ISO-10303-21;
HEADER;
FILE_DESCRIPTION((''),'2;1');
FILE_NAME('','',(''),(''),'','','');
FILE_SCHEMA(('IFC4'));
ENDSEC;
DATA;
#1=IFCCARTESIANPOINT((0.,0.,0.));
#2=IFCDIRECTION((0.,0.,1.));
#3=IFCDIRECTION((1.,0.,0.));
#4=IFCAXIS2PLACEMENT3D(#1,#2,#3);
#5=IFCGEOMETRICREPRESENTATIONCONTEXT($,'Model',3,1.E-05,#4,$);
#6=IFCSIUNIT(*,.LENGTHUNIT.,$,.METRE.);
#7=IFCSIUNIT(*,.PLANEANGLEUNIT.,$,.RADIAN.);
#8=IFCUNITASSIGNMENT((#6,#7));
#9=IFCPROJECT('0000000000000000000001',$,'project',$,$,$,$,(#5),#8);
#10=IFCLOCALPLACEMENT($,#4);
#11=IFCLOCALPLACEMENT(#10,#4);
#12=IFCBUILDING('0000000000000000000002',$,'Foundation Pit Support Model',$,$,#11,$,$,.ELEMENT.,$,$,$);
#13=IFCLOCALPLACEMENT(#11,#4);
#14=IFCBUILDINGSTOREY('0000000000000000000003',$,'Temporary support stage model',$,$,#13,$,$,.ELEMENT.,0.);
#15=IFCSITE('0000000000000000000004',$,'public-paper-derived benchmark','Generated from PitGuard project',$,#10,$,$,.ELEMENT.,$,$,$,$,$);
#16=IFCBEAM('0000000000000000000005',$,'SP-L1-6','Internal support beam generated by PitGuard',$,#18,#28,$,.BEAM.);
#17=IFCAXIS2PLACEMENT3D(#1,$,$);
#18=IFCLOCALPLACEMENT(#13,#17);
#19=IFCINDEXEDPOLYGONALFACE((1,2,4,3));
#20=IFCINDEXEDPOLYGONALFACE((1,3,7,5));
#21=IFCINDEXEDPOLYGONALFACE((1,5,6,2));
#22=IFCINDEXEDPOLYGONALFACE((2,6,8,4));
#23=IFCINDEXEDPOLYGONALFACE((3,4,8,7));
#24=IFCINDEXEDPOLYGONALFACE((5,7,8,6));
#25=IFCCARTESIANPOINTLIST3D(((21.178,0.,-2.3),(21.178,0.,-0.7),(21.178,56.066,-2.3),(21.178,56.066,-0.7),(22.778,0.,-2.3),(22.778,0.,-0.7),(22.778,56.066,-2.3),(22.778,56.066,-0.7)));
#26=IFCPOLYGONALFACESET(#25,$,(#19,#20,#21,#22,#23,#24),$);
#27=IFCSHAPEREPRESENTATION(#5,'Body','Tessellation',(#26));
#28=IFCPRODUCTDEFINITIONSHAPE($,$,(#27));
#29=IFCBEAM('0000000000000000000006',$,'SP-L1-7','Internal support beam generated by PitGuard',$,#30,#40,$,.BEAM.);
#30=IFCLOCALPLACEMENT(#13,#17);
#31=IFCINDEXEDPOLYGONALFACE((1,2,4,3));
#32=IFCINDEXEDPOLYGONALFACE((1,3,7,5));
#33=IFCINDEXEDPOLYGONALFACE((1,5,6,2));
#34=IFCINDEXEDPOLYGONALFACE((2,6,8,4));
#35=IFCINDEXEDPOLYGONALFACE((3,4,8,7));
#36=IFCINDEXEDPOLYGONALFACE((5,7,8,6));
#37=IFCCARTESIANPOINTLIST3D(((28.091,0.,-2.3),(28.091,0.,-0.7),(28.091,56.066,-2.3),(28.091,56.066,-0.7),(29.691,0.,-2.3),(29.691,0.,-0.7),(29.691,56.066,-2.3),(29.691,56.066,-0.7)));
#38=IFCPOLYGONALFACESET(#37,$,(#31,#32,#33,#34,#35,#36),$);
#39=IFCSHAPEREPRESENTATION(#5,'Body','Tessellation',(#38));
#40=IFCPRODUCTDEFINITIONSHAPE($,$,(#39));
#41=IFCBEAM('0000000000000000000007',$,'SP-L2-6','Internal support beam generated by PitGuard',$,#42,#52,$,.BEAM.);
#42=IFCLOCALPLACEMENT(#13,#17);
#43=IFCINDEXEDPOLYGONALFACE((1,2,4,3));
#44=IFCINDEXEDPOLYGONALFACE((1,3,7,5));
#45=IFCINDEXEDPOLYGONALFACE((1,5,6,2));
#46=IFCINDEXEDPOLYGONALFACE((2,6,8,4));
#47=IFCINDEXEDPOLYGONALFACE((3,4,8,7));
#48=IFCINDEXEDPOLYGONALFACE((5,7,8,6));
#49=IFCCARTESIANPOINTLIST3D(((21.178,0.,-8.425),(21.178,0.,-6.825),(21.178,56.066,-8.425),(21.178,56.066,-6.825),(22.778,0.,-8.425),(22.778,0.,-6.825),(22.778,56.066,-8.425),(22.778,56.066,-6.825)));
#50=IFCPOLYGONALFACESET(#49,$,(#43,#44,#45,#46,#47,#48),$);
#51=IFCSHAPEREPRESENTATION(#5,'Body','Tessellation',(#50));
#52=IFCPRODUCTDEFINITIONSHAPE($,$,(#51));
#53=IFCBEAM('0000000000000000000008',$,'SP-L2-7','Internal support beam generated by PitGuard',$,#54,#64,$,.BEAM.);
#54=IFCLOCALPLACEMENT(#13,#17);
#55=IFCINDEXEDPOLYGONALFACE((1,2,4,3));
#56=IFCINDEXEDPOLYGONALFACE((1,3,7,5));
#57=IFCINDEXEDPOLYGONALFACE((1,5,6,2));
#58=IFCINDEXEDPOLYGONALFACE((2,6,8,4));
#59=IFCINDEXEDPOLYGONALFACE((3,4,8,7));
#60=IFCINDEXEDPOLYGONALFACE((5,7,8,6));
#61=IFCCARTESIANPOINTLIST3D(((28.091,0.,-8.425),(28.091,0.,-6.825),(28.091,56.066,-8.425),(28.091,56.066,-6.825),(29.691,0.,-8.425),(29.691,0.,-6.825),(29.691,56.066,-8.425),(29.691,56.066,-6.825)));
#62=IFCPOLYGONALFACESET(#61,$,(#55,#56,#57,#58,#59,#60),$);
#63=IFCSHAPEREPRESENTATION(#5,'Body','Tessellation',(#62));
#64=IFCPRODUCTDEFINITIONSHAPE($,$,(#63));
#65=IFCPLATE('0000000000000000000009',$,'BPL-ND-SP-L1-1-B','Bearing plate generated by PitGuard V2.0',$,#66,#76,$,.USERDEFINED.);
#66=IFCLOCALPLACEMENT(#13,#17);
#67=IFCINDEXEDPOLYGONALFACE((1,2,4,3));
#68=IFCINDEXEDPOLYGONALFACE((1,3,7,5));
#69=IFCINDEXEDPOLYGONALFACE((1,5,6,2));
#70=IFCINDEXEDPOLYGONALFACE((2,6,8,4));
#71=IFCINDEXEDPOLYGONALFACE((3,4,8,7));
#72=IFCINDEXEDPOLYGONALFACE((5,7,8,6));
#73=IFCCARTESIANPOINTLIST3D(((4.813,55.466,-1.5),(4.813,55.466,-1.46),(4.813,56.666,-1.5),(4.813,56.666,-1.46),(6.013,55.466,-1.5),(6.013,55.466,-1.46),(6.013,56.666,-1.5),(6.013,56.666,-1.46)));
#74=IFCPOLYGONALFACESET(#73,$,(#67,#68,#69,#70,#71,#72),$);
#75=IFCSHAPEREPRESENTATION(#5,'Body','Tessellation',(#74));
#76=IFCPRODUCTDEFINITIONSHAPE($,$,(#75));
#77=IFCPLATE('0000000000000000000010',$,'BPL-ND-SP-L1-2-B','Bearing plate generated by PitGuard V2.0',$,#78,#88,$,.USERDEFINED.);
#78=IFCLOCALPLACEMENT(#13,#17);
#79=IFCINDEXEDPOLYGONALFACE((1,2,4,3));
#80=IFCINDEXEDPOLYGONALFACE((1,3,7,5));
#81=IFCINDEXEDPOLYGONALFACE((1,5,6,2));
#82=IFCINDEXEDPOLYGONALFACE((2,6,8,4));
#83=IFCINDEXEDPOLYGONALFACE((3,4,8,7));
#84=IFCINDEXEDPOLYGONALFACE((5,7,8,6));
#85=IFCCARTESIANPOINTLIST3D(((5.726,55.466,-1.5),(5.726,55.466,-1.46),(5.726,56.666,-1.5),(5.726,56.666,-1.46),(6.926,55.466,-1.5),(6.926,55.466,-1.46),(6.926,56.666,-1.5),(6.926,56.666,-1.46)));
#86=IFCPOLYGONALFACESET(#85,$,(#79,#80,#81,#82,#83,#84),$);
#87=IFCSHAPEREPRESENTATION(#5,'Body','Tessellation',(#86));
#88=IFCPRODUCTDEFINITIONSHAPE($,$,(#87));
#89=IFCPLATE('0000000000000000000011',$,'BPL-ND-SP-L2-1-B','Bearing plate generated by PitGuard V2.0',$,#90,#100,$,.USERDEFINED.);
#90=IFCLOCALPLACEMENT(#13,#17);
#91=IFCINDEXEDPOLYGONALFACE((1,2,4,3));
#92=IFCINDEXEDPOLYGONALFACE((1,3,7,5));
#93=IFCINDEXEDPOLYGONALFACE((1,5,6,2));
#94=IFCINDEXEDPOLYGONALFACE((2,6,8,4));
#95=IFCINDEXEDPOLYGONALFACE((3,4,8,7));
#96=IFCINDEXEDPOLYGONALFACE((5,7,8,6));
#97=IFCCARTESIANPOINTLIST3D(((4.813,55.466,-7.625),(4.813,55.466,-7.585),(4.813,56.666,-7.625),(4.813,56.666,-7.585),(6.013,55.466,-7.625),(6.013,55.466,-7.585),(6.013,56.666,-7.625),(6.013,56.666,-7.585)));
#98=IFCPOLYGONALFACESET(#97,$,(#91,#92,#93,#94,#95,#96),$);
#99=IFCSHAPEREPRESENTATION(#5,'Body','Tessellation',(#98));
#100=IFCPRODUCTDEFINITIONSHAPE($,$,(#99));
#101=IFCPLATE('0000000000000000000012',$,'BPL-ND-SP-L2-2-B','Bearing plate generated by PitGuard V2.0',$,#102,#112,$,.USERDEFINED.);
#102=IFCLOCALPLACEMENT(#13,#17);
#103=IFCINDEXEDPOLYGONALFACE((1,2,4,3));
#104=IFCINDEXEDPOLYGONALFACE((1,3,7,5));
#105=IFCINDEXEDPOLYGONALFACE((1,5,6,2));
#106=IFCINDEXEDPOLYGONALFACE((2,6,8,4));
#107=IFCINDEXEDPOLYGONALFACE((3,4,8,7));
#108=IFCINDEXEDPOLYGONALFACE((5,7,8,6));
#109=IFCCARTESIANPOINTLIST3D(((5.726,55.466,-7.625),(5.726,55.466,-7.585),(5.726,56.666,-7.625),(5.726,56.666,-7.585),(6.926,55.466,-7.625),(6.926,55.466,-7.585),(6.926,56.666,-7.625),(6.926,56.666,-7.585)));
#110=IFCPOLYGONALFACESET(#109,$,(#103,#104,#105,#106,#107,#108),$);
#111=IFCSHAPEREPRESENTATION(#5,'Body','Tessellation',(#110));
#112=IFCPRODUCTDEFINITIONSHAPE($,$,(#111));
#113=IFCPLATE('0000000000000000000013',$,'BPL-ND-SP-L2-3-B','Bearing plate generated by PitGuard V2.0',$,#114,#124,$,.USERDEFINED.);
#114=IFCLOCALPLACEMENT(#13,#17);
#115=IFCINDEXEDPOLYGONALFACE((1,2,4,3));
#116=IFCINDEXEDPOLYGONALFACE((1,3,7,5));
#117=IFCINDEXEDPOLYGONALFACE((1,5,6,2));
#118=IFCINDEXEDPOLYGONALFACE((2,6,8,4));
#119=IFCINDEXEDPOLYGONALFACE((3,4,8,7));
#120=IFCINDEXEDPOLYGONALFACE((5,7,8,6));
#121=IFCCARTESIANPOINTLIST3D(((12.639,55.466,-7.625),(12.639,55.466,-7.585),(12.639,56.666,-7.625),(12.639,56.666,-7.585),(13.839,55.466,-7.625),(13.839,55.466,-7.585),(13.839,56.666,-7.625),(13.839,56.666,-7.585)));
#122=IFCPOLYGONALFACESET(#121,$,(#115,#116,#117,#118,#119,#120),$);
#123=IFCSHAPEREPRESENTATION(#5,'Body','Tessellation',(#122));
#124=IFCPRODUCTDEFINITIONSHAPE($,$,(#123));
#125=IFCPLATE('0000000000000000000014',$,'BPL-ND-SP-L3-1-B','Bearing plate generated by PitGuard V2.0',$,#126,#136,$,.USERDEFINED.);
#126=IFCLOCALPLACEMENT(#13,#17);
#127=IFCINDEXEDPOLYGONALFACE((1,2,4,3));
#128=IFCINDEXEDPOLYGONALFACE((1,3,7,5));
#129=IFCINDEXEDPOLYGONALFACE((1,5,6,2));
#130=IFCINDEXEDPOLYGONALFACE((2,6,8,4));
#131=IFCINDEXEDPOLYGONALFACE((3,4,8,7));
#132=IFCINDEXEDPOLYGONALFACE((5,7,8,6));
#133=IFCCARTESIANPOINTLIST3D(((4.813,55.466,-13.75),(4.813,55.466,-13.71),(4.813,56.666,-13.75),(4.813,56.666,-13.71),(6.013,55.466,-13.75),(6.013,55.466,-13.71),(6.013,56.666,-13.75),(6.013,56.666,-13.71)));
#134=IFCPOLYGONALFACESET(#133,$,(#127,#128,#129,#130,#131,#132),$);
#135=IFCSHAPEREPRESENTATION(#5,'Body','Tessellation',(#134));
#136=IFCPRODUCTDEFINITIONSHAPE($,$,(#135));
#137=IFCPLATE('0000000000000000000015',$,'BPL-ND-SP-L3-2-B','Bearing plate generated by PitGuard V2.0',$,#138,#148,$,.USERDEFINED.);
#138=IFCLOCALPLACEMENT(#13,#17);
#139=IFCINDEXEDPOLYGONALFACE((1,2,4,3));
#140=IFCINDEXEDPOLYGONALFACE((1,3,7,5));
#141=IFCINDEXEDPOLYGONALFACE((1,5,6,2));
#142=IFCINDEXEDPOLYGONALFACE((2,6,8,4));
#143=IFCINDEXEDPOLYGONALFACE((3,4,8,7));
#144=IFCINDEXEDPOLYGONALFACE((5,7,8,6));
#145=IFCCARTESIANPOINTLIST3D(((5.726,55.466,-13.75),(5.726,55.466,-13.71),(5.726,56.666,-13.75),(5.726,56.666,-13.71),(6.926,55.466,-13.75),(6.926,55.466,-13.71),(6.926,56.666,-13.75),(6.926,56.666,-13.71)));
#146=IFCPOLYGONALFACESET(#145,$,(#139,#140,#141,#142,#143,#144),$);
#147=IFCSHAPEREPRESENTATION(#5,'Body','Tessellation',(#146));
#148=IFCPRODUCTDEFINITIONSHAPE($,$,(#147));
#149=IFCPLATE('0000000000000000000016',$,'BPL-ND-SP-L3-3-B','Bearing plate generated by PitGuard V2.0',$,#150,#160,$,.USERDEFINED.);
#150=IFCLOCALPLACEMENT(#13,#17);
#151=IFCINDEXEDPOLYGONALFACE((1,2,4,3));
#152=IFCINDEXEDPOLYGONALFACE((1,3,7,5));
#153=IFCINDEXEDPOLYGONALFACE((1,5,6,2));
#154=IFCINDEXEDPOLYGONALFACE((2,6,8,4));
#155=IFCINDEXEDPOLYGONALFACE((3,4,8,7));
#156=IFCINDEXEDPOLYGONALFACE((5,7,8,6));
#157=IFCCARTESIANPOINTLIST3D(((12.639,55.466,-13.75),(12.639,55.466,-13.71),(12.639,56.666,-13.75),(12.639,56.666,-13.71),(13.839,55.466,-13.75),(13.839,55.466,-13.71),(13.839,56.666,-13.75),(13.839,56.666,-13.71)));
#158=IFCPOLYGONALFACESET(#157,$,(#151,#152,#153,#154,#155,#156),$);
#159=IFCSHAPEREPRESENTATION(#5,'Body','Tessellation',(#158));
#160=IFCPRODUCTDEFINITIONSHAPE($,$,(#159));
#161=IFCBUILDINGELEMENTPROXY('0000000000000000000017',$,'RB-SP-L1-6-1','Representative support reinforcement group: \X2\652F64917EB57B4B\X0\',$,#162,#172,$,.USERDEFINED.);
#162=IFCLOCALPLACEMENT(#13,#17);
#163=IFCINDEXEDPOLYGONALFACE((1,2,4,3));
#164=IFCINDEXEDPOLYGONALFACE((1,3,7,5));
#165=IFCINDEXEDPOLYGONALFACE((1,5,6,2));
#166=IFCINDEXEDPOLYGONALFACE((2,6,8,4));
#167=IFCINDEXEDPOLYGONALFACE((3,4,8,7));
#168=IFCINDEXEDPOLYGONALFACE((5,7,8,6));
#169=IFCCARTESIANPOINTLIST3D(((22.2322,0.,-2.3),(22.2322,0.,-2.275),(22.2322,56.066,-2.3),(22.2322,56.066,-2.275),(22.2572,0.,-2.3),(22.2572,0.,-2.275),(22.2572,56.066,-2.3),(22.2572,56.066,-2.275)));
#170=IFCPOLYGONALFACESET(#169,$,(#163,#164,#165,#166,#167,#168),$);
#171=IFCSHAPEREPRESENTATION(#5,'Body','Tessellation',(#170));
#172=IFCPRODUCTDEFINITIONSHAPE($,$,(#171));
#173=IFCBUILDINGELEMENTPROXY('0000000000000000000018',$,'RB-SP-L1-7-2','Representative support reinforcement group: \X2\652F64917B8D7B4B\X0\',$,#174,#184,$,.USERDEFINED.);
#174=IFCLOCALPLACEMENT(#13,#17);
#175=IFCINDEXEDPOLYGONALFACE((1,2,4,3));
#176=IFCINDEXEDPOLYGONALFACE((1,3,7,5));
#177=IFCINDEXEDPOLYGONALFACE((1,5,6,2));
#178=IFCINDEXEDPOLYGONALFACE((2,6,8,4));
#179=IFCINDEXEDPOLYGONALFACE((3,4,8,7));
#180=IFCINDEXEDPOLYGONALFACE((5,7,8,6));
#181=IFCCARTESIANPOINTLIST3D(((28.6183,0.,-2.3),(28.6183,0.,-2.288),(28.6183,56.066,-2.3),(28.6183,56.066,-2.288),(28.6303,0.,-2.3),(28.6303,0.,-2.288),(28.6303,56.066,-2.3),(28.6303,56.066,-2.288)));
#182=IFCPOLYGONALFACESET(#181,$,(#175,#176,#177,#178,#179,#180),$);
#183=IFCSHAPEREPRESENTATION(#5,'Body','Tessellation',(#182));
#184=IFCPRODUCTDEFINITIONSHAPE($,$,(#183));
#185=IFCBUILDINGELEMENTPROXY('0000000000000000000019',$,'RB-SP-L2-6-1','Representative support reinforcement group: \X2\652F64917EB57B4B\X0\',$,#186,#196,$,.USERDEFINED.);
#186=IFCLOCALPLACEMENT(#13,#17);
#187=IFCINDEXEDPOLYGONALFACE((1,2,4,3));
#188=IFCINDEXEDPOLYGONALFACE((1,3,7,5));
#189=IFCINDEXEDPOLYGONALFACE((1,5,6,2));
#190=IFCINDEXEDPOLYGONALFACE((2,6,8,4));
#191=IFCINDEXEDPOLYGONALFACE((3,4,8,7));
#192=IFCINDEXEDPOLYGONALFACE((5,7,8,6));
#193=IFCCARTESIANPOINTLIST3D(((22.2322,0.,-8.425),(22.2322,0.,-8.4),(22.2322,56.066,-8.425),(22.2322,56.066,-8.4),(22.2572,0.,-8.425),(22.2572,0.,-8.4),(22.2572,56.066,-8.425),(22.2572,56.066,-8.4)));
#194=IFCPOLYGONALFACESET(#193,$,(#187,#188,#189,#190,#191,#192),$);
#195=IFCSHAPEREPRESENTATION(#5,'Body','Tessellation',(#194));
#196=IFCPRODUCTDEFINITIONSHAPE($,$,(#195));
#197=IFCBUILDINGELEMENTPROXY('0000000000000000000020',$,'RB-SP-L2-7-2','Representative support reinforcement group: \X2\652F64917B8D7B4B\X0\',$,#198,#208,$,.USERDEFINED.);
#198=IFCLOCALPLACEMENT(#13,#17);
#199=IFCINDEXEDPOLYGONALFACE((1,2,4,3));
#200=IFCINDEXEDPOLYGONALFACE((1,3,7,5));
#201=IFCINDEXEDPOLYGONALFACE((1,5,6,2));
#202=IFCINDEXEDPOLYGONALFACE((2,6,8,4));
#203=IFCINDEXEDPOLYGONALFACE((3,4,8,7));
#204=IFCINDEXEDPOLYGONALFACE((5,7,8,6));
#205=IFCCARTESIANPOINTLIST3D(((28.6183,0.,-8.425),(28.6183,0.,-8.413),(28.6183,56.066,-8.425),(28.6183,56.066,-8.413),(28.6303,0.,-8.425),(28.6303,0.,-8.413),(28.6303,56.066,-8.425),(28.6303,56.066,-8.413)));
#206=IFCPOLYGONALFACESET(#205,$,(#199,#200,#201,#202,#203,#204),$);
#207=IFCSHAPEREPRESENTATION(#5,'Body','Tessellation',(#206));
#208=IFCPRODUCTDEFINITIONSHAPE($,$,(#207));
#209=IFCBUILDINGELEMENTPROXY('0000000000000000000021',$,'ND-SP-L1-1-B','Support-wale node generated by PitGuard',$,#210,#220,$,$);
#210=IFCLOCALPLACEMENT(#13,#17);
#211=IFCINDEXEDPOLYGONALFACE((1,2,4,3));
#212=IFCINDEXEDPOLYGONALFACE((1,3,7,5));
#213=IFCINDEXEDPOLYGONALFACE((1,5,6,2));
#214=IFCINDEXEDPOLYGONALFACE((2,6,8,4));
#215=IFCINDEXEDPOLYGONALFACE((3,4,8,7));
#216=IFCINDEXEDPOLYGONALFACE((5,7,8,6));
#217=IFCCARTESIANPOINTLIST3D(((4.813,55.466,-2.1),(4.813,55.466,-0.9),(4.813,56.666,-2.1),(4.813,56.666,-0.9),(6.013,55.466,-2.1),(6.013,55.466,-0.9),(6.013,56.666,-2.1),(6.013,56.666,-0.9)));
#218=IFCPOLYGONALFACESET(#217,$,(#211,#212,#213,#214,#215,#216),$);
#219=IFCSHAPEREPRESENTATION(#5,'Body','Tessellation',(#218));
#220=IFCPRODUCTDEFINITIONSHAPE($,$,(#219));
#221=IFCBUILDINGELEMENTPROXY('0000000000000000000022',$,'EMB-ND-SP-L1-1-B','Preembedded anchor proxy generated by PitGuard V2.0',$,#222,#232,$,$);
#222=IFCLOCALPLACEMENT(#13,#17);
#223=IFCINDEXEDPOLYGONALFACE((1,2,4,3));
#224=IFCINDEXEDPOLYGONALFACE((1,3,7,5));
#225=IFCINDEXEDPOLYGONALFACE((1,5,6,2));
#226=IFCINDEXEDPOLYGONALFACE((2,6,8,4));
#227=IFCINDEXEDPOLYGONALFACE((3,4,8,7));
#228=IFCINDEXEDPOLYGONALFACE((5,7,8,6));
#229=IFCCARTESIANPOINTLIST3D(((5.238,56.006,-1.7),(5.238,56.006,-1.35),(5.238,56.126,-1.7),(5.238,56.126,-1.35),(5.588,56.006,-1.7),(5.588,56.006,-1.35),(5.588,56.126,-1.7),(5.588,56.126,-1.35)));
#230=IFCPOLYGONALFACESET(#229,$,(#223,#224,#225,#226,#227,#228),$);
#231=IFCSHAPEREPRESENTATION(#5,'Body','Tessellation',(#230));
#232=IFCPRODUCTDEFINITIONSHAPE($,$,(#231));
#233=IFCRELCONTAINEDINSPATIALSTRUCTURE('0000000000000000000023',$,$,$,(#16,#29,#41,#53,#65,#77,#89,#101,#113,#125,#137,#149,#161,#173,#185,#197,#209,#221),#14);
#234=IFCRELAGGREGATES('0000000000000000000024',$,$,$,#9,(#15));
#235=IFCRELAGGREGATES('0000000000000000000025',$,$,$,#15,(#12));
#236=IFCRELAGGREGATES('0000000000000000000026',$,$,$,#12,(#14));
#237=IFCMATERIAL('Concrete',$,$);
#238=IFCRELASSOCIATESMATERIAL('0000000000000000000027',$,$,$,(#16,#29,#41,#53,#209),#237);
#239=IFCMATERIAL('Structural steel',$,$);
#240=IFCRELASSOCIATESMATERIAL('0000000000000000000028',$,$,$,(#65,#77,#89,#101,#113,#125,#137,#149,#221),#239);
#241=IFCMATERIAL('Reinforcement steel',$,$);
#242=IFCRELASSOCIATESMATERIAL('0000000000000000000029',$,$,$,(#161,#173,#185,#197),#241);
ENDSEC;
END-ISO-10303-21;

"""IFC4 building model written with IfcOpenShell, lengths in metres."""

from ifc_helpers import new_model, si_unit, frame, origin_with_axes, origin_2d, place, context, project, spatial, rectangle, extrude, material, element, save


model = new_model("IFC4")

# Units and contexts
model_context = context("Model", 3, precision=1e-05, world=origin_with_axes())
ifc_project = project(units=[si_unit("LENGTHUNIT", "METRE"), si_unit("PLANEANGLEUNIT", "RADIAN")], contexts=[model_context])

# Site, building, storey
site_placement = place(None, origin_with_axes())
site = spatial("IfcSite", under=ifc_project, at=site_placement, Name="public-paper-derived benchmark", Description="Generated from PitGuard project", CompositionType="ELEMENT")
building_placement = place(site_placement, origin_with_axes())
building = spatial("IfcBuilding", under=site, at=building_placement, Name="Foundation Pit Support Model", CompositionType="ELEMENT")
storey_placement = place(building_placement, origin_with_axes())
storey = spatial("IfcBuildingStorey", under=building, at=storey_placement, Name="Temporary support stage model", CompositionType="ELEMENT", Elevation=0.0)

# Beams
ifc_material_1 = material(Name="Concrete")
for number, where, z_axis, x_axis, name in (
    (1, (21.978, 28.033, -2.3), (0.0, 0.0, 1.0), (0.0, 1.0, 0.0), "SP-L1-6"),
    (2, (28.891, 28.033, -2.3), (0.0, 0.0, 1.0), (0.0, 1.0, 0.0), "SP-L1-7"),
    (3, (21.978, 28.033, -8.425), (0.0, 0.0, 1.0), (0.0, 1.0, 0.0), "SP-L2-6"),
    (4, (28.891, 28.033, -8.425), (0.0, 0.0, 1.0), (0.0, 1.0, 0.0), "SP-L2-7"),
):
    element("IfcBeam", number, at=place(storey_placement, frame(where, z_axis=z_axis, x_axis=x_axis)), inside=storey, material=ifc_material_1, Name=name, Description="Internal support beam generated by PitGuard", PredefinedType="BEAM", context=model_context, shape_type="SweptSolid", body=[
        extrude(rectangle(XDim=56.066, YDim=1.6, at=origin_2d()), origin_with_axes(), (0.0, 0.0, 1.0), 1.6),
    ])

# Plates
ifc_material_2 = material(Name="Structural steel")
for number, where, z_axis, x_axis, name in (
    (5, (5.413, 56.066, -1.5), (0.0, 0.0, 1.0), (1.0, 0.0, 0.0), "BPL-ND-SP-L1-1-B"),
    (6, (6.326, 56.066, -1.5), (0.0, 0.0, 1.0), (1.0, 0.0, 0.0), "BPL-ND-SP-L1-2-B"),
    (7, (5.413, 56.066, -7.625), (0.0, 0.0, 1.0), (1.0, 0.0, 0.0), "BPL-ND-SP-L2-1-B"),
    (8, (6.326, 56.066, -7.625), (0.0, 0.0, 1.0), (1.0, 0.0, 0.0), "BPL-ND-SP-L2-2-B"),
    (9, (13.239, 56.066, -7.625), (0.0, 0.0, 1.0), (1.0, 0.0, 0.0), "BPL-ND-SP-L2-3-B"),
    (10, (5.413, 56.066, -13.75), (0.0, 0.0, 1.0), (1.0, 0.0, 0.0), "BPL-ND-SP-L3-1-B"),
    (11, (6.326, 56.066, -13.75), (0.0, 0.0, 1.0), (1.0, 0.0, 0.0), "BPL-ND-SP-L3-2-B"),
    (12, (13.239, 56.066, -13.75), (0.0, 0.0, 1.0), (1.0, 0.0, 0.0), "BPL-ND-SP-L3-3-B"),
):
    element("IfcPlate", number, at=place(storey_placement, frame(where, z_axis=z_axis, x_axis=x_axis)), inside=storey, material=ifc_material_2, Name=name, Description="Bearing plate generated by PitGuard V2.0", PredefinedType="USERDEFINED", context=model_context, shape_type="SweptSolid", body=[
        extrude(rectangle(XDim=1.2, YDim=1.2, at=origin_2d()), origin_with_axes(), (0.0, 0.0, 1.0), 0.04),
    ])

# Building element proxies
ifc_material_3 = material(Name="Reinforcement steel")
proxy_1_placement = place(storey_placement, frame((22.2447, 28.033, -2.3), z_axis=(0.0, 0.0, 1.0), x_axis=(0.0, 1.0, 0.0)))
element("IfcBuildingElementProxy", 13, at=proxy_1_placement, inside=storey, material=ifc_material_3, Name="RB-SP-L1-6-1", Description="Representative support reinforcement group: 支撑纵筋", PredefinedType="USERDEFINED", context=model_context, shape_type="SweptSolid", body=[
    extrude(rectangle(XDim=56.066, YDim=0.025, at=origin_2d()), origin_with_axes(), (0.0, 0.0, 1.0), 0.025),
])
proxy_2_placement = place(storey_placement, frame((28.6243, 28.033, -2.3), z_axis=(0.0, 0.0, 1.0), x_axis=(0.0, 1.0, 0.0)))
element("IfcBuildingElementProxy", 14, at=proxy_2_placement, inside=storey, material=ifc_material_3, Name="RB-SP-L1-7-2", Description="Representative support reinforcement group: 支撑箍筋", PredefinedType="USERDEFINED", context=model_context, shape_type="SweptSolid", body=[
    extrude(rectangle(XDim=56.066, YDim=0.012, at=origin_2d()), origin_with_axes(), (0.0, 0.0, 1.0), 0.012),
])
proxy_3_placement = place(storey_placement, frame((22.2447, 28.033, -8.425), z_axis=(0.0, 0.0, 1.0), x_axis=(0.0, 1.0, 0.0)))
element("IfcBuildingElementProxy", 15, at=proxy_3_placement, inside=storey, material=ifc_material_3, Name="RB-SP-L2-6-1", Description="Representative support reinforcement group: 支撑纵筋", PredefinedType="USERDEFINED", context=model_context, shape_type="SweptSolid", body=[
    extrude(rectangle(XDim=56.066, YDim=0.025, at=origin_2d()), origin_with_axes(), (0.0, 0.0, 1.0), 0.025),
])
proxy_4_placement = place(storey_placement, frame((28.6243, 28.033, -8.425), z_axis=(0.0, 0.0, 1.0), x_axis=(0.0, 1.0, 0.0)))
element("IfcBuildingElementProxy", 16, at=proxy_4_placement, inside=storey, material=ifc_material_3, Name="RB-SP-L2-7-2", Description="Representative support reinforcement group: 支撑箍筋", PredefinedType="USERDEFINED", context=model_context, shape_type="SweptSolid", body=[
    extrude(rectangle(XDim=56.066, YDim=0.012, at=origin_2d()), origin_with_axes(), (0.0, 0.0, 1.0), 0.012),
])
proxy_5_placement = place(storey_placement, frame((5.413, 56.066, -2.1), z_axis=(0.0, 0.0, 1.0), x_axis=(1.0, 0.0, 0.0)))
element("IfcBuildingElementProxy", 17, at=proxy_5_placement, inside=storey, material=ifc_material_1, Name="ND-SP-L1-1-B", Description="Support-wale node generated by PitGuard", context=model_context, shape_type="SweptSolid", body=[
    extrude(rectangle(XDim=1.2, YDim=1.2, at=origin_2d()), origin_with_axes(), (0.0, 0.0, 1.0), 1.2),
])
proxy_6_placement = place(storey_placement, frame((5.413, 56.066, -1.7), z_axis=(0.0, 0.0, 1.0), x_axis=(1.0, 0.0, 0.0)))
element("IfcBuildingElementProxy", 18, at=proxy_6_placement, inside=storey, material=ifc_material_2, Name="EMB-ND-SP-L1-1-B", Description="Preembedded anchor proxy generated by PitGuard V2.0", context=model_context, shape_type="SweptSolid", body=[
    extrude(rectangle(XDim=0.35, YDim=0.12, at=origin_2d()), origin_with_axes(), (0.0, 0.0, 1.0), 0.35),
])

save(model, "model.ifc")
